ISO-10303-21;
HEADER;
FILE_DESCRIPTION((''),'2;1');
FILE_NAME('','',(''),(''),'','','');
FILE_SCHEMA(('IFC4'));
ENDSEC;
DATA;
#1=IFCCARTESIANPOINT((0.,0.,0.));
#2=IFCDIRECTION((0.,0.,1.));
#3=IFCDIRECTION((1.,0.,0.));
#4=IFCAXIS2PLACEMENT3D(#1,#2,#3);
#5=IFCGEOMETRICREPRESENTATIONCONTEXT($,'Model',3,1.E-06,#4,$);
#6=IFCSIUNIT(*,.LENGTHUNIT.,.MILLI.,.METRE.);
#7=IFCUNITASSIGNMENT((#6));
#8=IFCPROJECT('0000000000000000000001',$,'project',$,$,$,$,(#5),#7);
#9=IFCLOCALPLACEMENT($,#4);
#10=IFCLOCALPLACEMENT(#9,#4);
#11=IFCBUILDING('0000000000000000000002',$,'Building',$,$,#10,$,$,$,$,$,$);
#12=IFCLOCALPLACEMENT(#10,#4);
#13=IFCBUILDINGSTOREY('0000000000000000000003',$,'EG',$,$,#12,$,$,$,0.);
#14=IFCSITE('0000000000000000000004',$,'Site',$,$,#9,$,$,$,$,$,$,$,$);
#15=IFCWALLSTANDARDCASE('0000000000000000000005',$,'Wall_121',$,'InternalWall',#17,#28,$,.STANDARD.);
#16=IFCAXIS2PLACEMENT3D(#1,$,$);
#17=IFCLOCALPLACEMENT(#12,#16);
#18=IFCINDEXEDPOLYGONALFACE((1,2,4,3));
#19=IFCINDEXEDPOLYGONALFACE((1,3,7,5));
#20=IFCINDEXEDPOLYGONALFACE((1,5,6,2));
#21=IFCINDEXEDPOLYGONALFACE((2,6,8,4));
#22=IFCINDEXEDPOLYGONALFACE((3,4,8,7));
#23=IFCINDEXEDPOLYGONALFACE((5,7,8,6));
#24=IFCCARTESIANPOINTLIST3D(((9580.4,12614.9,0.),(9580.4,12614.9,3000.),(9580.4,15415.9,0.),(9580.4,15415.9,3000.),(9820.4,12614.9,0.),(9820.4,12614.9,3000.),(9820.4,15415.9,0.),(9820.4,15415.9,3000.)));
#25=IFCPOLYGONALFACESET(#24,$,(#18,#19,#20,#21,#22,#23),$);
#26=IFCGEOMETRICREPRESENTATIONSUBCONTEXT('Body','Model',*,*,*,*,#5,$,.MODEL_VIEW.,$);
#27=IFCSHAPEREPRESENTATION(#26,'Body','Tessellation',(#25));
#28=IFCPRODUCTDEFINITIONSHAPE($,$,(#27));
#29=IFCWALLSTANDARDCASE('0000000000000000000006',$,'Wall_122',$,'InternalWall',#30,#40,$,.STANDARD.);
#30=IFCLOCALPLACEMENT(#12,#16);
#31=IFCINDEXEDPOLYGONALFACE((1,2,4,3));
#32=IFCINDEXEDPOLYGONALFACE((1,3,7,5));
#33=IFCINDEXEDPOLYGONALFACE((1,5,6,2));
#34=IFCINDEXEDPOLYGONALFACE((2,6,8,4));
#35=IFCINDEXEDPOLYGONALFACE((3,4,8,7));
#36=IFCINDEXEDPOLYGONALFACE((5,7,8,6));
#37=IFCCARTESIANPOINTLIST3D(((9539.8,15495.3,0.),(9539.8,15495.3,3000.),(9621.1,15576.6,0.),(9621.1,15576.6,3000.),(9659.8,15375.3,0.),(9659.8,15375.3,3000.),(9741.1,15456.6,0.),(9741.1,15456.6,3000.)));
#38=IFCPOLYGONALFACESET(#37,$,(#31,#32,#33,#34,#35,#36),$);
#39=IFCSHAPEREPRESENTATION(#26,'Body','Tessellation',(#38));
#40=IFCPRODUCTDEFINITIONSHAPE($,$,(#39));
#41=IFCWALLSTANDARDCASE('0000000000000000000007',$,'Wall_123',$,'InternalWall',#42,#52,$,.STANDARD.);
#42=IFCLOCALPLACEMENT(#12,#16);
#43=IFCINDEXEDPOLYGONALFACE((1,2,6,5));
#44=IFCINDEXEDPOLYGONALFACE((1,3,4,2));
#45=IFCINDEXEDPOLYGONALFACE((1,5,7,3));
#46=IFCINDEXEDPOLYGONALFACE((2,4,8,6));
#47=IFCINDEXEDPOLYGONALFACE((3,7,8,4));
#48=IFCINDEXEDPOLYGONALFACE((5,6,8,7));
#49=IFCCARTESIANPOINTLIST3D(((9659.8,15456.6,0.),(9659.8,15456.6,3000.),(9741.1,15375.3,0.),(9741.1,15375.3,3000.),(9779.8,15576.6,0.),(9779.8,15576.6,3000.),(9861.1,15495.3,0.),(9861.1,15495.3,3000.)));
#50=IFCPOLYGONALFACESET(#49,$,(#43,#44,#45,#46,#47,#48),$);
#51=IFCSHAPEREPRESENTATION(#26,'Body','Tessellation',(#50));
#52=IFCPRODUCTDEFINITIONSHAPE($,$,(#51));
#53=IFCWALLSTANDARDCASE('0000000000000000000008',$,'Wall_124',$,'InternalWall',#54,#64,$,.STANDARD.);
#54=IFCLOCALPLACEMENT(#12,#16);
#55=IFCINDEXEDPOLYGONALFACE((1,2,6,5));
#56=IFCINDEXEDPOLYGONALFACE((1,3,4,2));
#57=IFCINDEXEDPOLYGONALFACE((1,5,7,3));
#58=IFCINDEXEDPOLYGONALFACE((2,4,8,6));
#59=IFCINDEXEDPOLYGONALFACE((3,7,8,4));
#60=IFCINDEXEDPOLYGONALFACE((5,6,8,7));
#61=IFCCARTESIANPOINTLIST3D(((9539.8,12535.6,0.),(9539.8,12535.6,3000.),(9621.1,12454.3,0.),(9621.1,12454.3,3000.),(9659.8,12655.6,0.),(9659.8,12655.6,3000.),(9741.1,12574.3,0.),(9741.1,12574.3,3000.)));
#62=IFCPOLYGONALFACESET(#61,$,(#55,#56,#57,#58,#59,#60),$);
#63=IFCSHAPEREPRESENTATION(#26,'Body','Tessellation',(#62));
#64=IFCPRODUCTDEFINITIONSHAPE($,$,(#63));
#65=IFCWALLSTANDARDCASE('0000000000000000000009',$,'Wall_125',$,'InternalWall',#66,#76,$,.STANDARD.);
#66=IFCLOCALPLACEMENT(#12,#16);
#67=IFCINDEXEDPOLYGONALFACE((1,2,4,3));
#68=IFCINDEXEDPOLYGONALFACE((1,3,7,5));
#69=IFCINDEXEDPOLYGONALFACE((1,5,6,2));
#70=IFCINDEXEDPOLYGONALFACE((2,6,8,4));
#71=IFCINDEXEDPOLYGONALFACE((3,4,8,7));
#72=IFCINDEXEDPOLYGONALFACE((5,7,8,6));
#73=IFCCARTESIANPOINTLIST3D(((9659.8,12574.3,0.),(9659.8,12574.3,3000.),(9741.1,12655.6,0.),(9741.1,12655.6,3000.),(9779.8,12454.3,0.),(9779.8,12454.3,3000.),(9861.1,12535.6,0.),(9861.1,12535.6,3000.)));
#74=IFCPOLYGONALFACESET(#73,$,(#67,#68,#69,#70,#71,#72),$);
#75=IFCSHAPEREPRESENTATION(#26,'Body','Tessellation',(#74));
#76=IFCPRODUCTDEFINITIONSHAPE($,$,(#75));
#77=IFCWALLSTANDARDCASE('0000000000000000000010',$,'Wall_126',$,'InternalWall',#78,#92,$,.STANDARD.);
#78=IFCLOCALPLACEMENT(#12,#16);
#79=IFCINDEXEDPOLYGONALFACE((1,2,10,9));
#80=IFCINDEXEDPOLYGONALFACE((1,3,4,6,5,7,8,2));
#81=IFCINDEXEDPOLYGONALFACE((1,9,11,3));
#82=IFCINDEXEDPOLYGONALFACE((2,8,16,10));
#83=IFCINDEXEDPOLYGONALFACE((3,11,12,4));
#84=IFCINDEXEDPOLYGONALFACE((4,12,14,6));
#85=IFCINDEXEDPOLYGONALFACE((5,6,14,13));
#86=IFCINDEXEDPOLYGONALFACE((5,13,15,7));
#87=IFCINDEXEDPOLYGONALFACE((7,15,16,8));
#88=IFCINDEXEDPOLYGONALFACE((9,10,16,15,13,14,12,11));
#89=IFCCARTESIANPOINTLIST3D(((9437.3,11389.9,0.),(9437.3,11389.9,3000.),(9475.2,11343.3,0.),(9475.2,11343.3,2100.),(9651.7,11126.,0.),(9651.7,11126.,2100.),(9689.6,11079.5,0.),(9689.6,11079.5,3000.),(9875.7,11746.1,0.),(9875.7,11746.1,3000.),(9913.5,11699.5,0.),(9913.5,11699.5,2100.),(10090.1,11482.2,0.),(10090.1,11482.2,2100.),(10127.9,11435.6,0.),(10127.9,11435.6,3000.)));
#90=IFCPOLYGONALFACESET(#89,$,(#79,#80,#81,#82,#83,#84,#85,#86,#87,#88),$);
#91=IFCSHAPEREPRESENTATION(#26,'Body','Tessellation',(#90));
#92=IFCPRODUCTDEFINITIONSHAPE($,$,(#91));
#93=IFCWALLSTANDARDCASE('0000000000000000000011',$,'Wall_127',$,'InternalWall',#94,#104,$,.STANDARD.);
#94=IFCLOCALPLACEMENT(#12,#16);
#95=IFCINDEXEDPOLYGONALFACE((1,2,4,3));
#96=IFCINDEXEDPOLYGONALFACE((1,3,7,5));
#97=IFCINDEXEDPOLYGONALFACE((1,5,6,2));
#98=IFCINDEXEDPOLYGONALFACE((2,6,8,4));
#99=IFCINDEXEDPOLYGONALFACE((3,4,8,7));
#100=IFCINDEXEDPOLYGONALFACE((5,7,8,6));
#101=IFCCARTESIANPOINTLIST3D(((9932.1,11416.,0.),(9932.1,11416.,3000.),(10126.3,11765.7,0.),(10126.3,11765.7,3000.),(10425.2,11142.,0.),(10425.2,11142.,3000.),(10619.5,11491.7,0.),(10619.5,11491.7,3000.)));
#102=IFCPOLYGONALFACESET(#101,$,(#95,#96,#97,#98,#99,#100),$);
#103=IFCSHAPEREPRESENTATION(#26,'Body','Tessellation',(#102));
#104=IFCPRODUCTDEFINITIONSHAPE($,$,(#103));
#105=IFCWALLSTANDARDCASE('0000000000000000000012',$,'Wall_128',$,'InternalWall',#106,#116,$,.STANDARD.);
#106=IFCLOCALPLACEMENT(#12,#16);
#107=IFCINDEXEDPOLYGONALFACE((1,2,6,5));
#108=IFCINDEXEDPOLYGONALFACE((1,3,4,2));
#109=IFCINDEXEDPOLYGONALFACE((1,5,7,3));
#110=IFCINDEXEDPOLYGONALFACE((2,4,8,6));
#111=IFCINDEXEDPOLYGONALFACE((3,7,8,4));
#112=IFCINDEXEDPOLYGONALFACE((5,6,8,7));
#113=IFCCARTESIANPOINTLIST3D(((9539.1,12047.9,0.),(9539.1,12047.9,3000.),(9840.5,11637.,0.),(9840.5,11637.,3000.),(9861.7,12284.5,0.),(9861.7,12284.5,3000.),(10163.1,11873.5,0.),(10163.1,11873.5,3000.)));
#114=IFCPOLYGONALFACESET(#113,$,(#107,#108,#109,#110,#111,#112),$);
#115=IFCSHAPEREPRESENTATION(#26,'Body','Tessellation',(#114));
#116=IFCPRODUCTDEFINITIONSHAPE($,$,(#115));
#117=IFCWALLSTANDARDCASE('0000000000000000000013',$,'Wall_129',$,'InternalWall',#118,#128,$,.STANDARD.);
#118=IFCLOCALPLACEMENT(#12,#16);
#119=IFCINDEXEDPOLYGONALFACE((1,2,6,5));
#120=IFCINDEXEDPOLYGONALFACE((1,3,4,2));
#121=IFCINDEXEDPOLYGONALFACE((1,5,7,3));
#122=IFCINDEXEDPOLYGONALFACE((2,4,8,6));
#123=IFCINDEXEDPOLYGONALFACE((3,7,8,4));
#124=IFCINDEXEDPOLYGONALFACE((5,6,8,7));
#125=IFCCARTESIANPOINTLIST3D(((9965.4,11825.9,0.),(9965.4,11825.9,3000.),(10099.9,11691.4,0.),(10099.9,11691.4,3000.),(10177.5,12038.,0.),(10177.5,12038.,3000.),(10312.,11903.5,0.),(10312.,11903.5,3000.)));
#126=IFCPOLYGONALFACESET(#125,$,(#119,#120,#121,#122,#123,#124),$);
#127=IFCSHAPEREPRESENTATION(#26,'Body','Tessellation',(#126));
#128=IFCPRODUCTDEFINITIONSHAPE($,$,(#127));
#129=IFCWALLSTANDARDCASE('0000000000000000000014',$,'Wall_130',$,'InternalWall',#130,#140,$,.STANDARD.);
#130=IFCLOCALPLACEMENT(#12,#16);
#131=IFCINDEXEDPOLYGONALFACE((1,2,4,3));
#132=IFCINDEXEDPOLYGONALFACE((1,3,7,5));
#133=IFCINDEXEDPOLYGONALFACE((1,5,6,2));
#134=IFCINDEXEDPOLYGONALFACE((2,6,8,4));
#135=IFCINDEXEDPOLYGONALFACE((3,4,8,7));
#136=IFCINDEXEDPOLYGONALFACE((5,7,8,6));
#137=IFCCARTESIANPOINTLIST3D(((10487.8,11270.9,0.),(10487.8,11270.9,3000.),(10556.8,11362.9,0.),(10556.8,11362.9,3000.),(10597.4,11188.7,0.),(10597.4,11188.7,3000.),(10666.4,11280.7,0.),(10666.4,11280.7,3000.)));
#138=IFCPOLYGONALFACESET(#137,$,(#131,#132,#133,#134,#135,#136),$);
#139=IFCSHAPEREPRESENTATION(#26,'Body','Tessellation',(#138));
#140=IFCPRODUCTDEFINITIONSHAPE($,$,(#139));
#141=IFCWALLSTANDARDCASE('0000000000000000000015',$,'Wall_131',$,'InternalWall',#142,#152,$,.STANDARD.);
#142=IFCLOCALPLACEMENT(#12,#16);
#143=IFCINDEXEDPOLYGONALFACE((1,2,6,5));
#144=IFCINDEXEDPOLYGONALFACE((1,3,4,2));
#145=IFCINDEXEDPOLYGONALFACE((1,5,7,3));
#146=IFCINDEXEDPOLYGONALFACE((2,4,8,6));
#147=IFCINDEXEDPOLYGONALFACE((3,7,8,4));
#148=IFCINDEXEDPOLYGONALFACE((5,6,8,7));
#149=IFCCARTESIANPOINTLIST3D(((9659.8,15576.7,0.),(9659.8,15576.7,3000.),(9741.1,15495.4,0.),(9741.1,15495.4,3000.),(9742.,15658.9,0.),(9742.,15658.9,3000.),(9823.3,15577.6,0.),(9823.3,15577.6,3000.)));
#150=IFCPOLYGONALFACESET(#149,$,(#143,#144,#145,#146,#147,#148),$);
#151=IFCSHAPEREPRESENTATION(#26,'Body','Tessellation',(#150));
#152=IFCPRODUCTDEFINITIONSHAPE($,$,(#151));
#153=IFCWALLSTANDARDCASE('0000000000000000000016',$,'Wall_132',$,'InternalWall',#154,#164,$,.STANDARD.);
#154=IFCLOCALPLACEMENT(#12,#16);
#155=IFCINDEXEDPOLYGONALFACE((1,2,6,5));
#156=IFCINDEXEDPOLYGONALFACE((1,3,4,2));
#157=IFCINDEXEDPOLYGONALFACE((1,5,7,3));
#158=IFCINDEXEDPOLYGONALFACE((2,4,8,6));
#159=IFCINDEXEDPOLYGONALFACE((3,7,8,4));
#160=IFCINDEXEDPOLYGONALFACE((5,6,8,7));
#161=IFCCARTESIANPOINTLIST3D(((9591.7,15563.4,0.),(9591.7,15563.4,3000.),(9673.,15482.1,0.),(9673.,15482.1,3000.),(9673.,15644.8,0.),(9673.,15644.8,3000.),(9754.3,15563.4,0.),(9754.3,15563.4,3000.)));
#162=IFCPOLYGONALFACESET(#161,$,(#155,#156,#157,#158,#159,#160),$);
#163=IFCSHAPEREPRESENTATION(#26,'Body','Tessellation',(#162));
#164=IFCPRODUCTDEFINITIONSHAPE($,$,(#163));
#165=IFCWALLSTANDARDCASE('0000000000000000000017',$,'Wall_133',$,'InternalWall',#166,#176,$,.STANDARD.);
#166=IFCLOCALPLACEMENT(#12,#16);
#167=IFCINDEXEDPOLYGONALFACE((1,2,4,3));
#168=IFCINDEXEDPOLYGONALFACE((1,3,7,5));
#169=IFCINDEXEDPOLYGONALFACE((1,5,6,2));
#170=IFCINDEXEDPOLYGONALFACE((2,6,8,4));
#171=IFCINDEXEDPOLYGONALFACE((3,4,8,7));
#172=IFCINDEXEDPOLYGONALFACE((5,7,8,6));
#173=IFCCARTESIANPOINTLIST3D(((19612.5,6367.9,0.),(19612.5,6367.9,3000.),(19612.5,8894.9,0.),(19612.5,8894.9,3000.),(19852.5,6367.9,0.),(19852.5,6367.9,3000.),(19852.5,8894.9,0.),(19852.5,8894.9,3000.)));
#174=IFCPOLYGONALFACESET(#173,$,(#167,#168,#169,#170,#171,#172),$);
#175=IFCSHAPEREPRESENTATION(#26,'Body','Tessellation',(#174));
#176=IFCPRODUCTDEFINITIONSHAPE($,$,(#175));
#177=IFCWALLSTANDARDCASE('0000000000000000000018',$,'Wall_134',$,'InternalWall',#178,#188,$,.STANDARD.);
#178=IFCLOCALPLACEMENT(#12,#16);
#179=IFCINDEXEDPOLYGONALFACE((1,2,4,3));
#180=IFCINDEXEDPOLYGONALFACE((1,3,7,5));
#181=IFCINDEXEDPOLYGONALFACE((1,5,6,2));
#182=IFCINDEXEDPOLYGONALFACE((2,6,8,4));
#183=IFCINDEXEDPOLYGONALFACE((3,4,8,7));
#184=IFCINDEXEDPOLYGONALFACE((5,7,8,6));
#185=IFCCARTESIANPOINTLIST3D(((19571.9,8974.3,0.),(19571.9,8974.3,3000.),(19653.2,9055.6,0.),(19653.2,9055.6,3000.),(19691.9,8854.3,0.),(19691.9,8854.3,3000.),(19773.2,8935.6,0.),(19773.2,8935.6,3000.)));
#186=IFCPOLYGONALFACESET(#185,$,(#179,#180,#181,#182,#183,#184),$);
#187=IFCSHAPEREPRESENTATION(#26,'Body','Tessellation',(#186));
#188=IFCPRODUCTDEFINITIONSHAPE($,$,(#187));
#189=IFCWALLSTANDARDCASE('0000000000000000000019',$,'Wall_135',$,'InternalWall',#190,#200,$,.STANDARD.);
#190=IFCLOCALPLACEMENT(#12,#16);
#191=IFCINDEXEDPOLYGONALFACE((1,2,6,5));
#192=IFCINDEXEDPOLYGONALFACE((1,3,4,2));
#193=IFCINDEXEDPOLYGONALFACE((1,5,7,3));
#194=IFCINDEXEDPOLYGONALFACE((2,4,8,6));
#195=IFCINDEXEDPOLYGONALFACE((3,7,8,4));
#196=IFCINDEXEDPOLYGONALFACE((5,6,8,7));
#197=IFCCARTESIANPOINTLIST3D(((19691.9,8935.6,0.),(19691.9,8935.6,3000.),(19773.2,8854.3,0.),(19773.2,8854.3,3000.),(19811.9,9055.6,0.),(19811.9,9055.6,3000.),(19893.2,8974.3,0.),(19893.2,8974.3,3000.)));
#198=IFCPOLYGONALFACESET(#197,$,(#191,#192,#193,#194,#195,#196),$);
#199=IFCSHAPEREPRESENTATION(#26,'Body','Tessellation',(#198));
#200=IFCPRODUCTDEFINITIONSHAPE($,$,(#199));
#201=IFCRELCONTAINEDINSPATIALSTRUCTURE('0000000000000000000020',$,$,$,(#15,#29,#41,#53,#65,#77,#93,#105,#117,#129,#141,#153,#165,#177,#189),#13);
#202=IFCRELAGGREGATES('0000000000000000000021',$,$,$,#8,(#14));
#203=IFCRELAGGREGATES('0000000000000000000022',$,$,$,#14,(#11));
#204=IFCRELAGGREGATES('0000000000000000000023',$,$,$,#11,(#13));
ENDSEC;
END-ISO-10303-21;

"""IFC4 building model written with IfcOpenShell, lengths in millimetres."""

from ifc_helpers import new_model, si_unit, frame, origin_with_axes, place, context, subcontext, project, spatial, rectangle, extrude, element, save


model = new_model("IFC4")

# Units and contexts
model_context = context("Model", 3, precision=1e-06, world=origin_with_axes())
body_context = subcontext(model_context, "Body", "Model", "MODEL_VIEW")
ifc_project = project(units=[si_unit("LENGTHUNIT", "METRE", prefix="MILLI")], contexts=[model_context])

# Site, building, storey
site_placement = place(None, origin_with_axes())
site = spatial("IfcSite", under=ifc_project, at=site_placement, Name="Site")
building_placement = place(site_placement, origin_with_axes())
building = spatial("IfcBuilding", under=site, at=building_placement, Name="Building")
storey_placement = place(building_placement, origin_with_axes())
storey = spatial("IfcBuildingStorey", under=building, at=storey_placement, Name="EG", Elevation=0.0)

# Walls
wall_1_placement = place(storey_placement, origin_with_axes())
element("IfcWallStandardCase", 1, at=wall_1_placement, inside=storey, Name="Wall_121", ObjectType="InternalWall", PredefinedType="STANDARD", context=body_context, shape_type="SweptSolid", body=[
    extrude(rectangle(XDim=2801.0, YDim=240.0), frame((9700.4, 14015.4, 0.0), z_axis=(0.0, 0.0, 1.0), x_axis=(0.0, -1.0, 0.0)), (0.0, 0.0, 1.0), 3000.0),
])
wall_2_placement = place(storey_placement, origin_with_axes())
element("IfcWallStandardCase", 2, at=wall_2_placement, inside=storey, Name="Wall_122", ObjectType="InternalWall", PredefinedType="STANDARD", context=body_context, shape_type="SweptSolid", body=[
    extrude(rectangle(XDim=169.7, YDim=115.0), frame((9640.4, 15475.9, 0.0), z_axis=(0.0, 0.0, 1.0), x_axis=(-0.707107, 0.707107, 0.0)), (0.0, 0.0, 1.0), 3000.0),
])
wall_3_placement = place(storey_placement, origin_with_axes())
element("IfcWallStandardCase", 3, at=wall_3_placement, inside=storey, Name="Wall_123", ObjectType="InternalWall", PredefinedType="STANDARD", context=body_context, shape_type="SweptSolid", body=[
    extrude(rectangle(XDim=169.7, YDim=115.0), frame((9760.4, 15475.9, 0.0), z_axis=(0.0, 0.0, 1.0), x_axis=(0.707107, 0.707107, 0.0)), (0.0, 0.0, 1.0), 3000.0),
])
wall_4_placement = place(storey_placement, origin_with_axes())
element("IfcWallStandardCase", 4, at=wall_4_placement, inside=storey, Name="Wall_124", ObjectType="InternalWall", PredefinedType="STANDARD", context=body_context, shape_type="SweptSolid", body=[
    extrude(rectangle(XDim=169.7, YDim=115.0), frame((9640.4, 12554.9, 0.0), z_axis=(0.0, 0.0, 1.0), x_axis=(-0.707107, -0.707107, 0.0)), (0.0, 0.0, 1.0), 3000.0),
])
wall_5_placement = place(storey_placement, origin_with_axes())
element("IfcWallStandardCase", 5, at=wall_5_placement, inside=storey, Name="Wall_125", ObjectType="InternalWall", PredefinedType="STANDARD", context=body_context, shape_type="SweptSolid", body=[
    extrude(rectangle(XDim=169.7, YDim=115.0), frame((9760.4, 12554.9, 0.0), z_axis=(0.0, 0.0, 1.0), x_axis=(0.707107, -0.707107, 0.0)), (0.0, 0.0, 1.0), 3000.0),
])

# Wall, opening
wall_6_placement = place(storey_placement, origin_with_axes())
wall_6 = element("IfcWallStandardCase", 6, at=wall_6_placement, inside=storey, Name="Wall_126", ObjectType="InternalWall", PredefinedType="STANDARD", context=body_context, shape_type="SweptSolid", body=[
    extrude(rectangle(XDim=564.8, YDim=400.0), frame((9782.6, 11412.8, 0.0), z_axis=(0.0, 0.0, 1.0), x_axis=(-0.776114, -0.630593, 0.0)), (0.0, 0.0, 1.0), 3000.0),
])
opening_1_placement = place(wall_6_placement, origin_with_axes())
element("IfcOpeningElement", 7, at=opening_1_placement, inside=storey, cuts=wall_6, context=body_context, shape_type="SweptSolid", body=[
    extrude(rectangle(XDim=1297.2, YDim=280.0), frame((9554.3, 11227.3, 0.0), z_axis=(0.0, 0.0, 1.0), x_axis=(-0.776114, -0.630593, 0.0)), (0.0, 0.0, 1.0), 2100.0),
])

# Walls
wall_7_placement = place(storey_placement, origin_with_axes())
element("IfcWallStandardCase", 8, at=wall_7_placement, inside=storey, Name="Wall_127", ObjectType="InternalWall", PredefinedType="STANDARD", context=body_context, shape_type="SweptSolid", body=[
    extrude(rectangle(XDim=564.1, YDim=400.0), frame((10275.8, 11453.9, 0.0), z_axis=(0.0, 0.0, 1.0), x_axis=(-0.874157, 0.485643, 0.0)), (0.0, 0.0, 1.0), 3000.0),
])
wall_8_placement = place(storey_placement, origin_with_axes())
element("IfcWallStandardCase", 9, at=wall_8_placement, inside=storey, Name="Wall_128", ObjectType="InternalWall", PredefinedType="STANDARD", context=body_context, shape_type="SweptSolid", body=[
    extrude(rectangle(XDim=509.6, YDim=400.0), frame((9851.1, 11960.7, 0.0), z_axis=(0.0, 0.0, 1.0), x_axis=(-0.591364, 0.806405, 0.0)), (0.0, 0.0, 1.0), 3000.0),
])
wall_9_placement = place(storey_placement, origin_with_axes())
element("IfcWallStandardCase", 10, at=wall_9_placement, inside=storey, Name="Wall_129", ObjectType="InternalWall", PredefinedType="STANDARD", context=body_context, shape_type="SweptSolid", body=[
    extrude(rectangle(XDim=190.2, YDim=300.0), frame((10138.7, 11864.7, 0.0), z_axis=(0.0, 0.0, 1.0), x_axis=(0.707107, -0.707107, 0.0)), (0.0, 0.0, 1.0), 3000.0),
])
wall_10_placement = place(storey_placement, origin_with_axes())
element("IfcWallStandardCase", 11, at=wall_10_placement, inside=storey, Name="Wall_130", ObjectType="InternalWall", PredefinedType="STANDARD", context=body_context, shape_type="SweptSolid", body=[
    extrude(rectangle(XDim=137.0, YDim=115.0), frame((10577.1, 11275.8, 0.0), z_axis=(0.0, 0.0, 1.0), x_axis=(-0.8, 0.6, 0.0)), (0.0, 0.0, 1.0), 3000.0),
])
wall_11_placement = place(storey_placement, origin_with_axes())
element("IfcWallStandardCase", 12, at=wall_11_placement, inside=storey, Name="Wall_131", ObjectType="InternalWall", PredefinedType="STANDARD", context=body_context, shape_type="SweptSolid", body=[
    extrude(rectangle(XDim=116.2, YDim=115.0), frame((9741.5, 15577.1, 0.0), z_axis=(0.0, 0.0, 1.0), x_axis=(-0.707107, -0.707107, 0.0)), (0.0, 0.0, 1.0), 3000.0),
])
wall_12_placement = place(storey_placement, origin_with_axes())
element("IfcWallStandardCase", 13, at=wall_12_placement, inside=storey, Name="Wall_132", ObjectType="InternalWall", PredefinedType="STANDARD", context=body_context, shape_type="SweptSolid", body=[
    extrude(rectangle(XDim=115.0, YDim=115.0), frame((9673.0, 15563.4, 0.0), z_axis=(0.0, 0.0, 1.0), x_axis=(0.707107, 0.707107, 0.0)), (0.0, 0.0, 1.0), 3000.0),
])
wall_13_placement = place(storey_placement, origin_with_axes())
element("IfcWallStandardCase", 14, at=wall_13_placement, inside=storey, Name="Wall_133", ObjectType="InternalWall", PredefinedType="STANDARD", context=body_context, shape_type="SweptSolid", body=[
    extrude(rectangle(XDim=2527.0, YDim=240.0), frame((19732.5, 7631.4, 0.0), z_axis=(0.0, 0.0, 1.0), x_axis=(0.0, -1.0, 0.0)), (0.0, 0.0, 1.0), 3000.0),
])
wall_14_placement = place(storey_placement, origin_with_axes())
element("IfcWallStandardCase", 15, at=wall_14_placement, inside=storey, Name="Wall_134", ObjectType="InternalWall", PredefinedType="STANDARD", context=body_context, shape_type="SweptSolid", body=[
    extrude(rectangle(XDim=169.7, YDim=115.0), frame((19672.5, 8954.9, 0.0), z_axis=(0.0, 0.0, 1.0), x_axis=(-0.707107, 0.707107, 0.0)), (0.0, 0.0, 1.0), 3000.0),
])
wall_15_placement = place(storey_placement, origin_with_axes())
element("IfcWallStandardCase", 16, at=wall_15_placement, inside=storey, Name="Wall_135", ObjectType="InternalWall", PredefinedType="STANDARD", context=body_context, shape_type="SweptSolid", body=[
    extrude(rectangle(XDim=169.7, YDim=115.0), frame((19792.5, 8954.9, 0.0), z_axis=(0.0, 0.0, 1.0), x_axis=(0.707107, 0.707107, 0.0)), (0.0, 0.0, 1.0), 3000.0),
])

save(model, "model.ifc")
